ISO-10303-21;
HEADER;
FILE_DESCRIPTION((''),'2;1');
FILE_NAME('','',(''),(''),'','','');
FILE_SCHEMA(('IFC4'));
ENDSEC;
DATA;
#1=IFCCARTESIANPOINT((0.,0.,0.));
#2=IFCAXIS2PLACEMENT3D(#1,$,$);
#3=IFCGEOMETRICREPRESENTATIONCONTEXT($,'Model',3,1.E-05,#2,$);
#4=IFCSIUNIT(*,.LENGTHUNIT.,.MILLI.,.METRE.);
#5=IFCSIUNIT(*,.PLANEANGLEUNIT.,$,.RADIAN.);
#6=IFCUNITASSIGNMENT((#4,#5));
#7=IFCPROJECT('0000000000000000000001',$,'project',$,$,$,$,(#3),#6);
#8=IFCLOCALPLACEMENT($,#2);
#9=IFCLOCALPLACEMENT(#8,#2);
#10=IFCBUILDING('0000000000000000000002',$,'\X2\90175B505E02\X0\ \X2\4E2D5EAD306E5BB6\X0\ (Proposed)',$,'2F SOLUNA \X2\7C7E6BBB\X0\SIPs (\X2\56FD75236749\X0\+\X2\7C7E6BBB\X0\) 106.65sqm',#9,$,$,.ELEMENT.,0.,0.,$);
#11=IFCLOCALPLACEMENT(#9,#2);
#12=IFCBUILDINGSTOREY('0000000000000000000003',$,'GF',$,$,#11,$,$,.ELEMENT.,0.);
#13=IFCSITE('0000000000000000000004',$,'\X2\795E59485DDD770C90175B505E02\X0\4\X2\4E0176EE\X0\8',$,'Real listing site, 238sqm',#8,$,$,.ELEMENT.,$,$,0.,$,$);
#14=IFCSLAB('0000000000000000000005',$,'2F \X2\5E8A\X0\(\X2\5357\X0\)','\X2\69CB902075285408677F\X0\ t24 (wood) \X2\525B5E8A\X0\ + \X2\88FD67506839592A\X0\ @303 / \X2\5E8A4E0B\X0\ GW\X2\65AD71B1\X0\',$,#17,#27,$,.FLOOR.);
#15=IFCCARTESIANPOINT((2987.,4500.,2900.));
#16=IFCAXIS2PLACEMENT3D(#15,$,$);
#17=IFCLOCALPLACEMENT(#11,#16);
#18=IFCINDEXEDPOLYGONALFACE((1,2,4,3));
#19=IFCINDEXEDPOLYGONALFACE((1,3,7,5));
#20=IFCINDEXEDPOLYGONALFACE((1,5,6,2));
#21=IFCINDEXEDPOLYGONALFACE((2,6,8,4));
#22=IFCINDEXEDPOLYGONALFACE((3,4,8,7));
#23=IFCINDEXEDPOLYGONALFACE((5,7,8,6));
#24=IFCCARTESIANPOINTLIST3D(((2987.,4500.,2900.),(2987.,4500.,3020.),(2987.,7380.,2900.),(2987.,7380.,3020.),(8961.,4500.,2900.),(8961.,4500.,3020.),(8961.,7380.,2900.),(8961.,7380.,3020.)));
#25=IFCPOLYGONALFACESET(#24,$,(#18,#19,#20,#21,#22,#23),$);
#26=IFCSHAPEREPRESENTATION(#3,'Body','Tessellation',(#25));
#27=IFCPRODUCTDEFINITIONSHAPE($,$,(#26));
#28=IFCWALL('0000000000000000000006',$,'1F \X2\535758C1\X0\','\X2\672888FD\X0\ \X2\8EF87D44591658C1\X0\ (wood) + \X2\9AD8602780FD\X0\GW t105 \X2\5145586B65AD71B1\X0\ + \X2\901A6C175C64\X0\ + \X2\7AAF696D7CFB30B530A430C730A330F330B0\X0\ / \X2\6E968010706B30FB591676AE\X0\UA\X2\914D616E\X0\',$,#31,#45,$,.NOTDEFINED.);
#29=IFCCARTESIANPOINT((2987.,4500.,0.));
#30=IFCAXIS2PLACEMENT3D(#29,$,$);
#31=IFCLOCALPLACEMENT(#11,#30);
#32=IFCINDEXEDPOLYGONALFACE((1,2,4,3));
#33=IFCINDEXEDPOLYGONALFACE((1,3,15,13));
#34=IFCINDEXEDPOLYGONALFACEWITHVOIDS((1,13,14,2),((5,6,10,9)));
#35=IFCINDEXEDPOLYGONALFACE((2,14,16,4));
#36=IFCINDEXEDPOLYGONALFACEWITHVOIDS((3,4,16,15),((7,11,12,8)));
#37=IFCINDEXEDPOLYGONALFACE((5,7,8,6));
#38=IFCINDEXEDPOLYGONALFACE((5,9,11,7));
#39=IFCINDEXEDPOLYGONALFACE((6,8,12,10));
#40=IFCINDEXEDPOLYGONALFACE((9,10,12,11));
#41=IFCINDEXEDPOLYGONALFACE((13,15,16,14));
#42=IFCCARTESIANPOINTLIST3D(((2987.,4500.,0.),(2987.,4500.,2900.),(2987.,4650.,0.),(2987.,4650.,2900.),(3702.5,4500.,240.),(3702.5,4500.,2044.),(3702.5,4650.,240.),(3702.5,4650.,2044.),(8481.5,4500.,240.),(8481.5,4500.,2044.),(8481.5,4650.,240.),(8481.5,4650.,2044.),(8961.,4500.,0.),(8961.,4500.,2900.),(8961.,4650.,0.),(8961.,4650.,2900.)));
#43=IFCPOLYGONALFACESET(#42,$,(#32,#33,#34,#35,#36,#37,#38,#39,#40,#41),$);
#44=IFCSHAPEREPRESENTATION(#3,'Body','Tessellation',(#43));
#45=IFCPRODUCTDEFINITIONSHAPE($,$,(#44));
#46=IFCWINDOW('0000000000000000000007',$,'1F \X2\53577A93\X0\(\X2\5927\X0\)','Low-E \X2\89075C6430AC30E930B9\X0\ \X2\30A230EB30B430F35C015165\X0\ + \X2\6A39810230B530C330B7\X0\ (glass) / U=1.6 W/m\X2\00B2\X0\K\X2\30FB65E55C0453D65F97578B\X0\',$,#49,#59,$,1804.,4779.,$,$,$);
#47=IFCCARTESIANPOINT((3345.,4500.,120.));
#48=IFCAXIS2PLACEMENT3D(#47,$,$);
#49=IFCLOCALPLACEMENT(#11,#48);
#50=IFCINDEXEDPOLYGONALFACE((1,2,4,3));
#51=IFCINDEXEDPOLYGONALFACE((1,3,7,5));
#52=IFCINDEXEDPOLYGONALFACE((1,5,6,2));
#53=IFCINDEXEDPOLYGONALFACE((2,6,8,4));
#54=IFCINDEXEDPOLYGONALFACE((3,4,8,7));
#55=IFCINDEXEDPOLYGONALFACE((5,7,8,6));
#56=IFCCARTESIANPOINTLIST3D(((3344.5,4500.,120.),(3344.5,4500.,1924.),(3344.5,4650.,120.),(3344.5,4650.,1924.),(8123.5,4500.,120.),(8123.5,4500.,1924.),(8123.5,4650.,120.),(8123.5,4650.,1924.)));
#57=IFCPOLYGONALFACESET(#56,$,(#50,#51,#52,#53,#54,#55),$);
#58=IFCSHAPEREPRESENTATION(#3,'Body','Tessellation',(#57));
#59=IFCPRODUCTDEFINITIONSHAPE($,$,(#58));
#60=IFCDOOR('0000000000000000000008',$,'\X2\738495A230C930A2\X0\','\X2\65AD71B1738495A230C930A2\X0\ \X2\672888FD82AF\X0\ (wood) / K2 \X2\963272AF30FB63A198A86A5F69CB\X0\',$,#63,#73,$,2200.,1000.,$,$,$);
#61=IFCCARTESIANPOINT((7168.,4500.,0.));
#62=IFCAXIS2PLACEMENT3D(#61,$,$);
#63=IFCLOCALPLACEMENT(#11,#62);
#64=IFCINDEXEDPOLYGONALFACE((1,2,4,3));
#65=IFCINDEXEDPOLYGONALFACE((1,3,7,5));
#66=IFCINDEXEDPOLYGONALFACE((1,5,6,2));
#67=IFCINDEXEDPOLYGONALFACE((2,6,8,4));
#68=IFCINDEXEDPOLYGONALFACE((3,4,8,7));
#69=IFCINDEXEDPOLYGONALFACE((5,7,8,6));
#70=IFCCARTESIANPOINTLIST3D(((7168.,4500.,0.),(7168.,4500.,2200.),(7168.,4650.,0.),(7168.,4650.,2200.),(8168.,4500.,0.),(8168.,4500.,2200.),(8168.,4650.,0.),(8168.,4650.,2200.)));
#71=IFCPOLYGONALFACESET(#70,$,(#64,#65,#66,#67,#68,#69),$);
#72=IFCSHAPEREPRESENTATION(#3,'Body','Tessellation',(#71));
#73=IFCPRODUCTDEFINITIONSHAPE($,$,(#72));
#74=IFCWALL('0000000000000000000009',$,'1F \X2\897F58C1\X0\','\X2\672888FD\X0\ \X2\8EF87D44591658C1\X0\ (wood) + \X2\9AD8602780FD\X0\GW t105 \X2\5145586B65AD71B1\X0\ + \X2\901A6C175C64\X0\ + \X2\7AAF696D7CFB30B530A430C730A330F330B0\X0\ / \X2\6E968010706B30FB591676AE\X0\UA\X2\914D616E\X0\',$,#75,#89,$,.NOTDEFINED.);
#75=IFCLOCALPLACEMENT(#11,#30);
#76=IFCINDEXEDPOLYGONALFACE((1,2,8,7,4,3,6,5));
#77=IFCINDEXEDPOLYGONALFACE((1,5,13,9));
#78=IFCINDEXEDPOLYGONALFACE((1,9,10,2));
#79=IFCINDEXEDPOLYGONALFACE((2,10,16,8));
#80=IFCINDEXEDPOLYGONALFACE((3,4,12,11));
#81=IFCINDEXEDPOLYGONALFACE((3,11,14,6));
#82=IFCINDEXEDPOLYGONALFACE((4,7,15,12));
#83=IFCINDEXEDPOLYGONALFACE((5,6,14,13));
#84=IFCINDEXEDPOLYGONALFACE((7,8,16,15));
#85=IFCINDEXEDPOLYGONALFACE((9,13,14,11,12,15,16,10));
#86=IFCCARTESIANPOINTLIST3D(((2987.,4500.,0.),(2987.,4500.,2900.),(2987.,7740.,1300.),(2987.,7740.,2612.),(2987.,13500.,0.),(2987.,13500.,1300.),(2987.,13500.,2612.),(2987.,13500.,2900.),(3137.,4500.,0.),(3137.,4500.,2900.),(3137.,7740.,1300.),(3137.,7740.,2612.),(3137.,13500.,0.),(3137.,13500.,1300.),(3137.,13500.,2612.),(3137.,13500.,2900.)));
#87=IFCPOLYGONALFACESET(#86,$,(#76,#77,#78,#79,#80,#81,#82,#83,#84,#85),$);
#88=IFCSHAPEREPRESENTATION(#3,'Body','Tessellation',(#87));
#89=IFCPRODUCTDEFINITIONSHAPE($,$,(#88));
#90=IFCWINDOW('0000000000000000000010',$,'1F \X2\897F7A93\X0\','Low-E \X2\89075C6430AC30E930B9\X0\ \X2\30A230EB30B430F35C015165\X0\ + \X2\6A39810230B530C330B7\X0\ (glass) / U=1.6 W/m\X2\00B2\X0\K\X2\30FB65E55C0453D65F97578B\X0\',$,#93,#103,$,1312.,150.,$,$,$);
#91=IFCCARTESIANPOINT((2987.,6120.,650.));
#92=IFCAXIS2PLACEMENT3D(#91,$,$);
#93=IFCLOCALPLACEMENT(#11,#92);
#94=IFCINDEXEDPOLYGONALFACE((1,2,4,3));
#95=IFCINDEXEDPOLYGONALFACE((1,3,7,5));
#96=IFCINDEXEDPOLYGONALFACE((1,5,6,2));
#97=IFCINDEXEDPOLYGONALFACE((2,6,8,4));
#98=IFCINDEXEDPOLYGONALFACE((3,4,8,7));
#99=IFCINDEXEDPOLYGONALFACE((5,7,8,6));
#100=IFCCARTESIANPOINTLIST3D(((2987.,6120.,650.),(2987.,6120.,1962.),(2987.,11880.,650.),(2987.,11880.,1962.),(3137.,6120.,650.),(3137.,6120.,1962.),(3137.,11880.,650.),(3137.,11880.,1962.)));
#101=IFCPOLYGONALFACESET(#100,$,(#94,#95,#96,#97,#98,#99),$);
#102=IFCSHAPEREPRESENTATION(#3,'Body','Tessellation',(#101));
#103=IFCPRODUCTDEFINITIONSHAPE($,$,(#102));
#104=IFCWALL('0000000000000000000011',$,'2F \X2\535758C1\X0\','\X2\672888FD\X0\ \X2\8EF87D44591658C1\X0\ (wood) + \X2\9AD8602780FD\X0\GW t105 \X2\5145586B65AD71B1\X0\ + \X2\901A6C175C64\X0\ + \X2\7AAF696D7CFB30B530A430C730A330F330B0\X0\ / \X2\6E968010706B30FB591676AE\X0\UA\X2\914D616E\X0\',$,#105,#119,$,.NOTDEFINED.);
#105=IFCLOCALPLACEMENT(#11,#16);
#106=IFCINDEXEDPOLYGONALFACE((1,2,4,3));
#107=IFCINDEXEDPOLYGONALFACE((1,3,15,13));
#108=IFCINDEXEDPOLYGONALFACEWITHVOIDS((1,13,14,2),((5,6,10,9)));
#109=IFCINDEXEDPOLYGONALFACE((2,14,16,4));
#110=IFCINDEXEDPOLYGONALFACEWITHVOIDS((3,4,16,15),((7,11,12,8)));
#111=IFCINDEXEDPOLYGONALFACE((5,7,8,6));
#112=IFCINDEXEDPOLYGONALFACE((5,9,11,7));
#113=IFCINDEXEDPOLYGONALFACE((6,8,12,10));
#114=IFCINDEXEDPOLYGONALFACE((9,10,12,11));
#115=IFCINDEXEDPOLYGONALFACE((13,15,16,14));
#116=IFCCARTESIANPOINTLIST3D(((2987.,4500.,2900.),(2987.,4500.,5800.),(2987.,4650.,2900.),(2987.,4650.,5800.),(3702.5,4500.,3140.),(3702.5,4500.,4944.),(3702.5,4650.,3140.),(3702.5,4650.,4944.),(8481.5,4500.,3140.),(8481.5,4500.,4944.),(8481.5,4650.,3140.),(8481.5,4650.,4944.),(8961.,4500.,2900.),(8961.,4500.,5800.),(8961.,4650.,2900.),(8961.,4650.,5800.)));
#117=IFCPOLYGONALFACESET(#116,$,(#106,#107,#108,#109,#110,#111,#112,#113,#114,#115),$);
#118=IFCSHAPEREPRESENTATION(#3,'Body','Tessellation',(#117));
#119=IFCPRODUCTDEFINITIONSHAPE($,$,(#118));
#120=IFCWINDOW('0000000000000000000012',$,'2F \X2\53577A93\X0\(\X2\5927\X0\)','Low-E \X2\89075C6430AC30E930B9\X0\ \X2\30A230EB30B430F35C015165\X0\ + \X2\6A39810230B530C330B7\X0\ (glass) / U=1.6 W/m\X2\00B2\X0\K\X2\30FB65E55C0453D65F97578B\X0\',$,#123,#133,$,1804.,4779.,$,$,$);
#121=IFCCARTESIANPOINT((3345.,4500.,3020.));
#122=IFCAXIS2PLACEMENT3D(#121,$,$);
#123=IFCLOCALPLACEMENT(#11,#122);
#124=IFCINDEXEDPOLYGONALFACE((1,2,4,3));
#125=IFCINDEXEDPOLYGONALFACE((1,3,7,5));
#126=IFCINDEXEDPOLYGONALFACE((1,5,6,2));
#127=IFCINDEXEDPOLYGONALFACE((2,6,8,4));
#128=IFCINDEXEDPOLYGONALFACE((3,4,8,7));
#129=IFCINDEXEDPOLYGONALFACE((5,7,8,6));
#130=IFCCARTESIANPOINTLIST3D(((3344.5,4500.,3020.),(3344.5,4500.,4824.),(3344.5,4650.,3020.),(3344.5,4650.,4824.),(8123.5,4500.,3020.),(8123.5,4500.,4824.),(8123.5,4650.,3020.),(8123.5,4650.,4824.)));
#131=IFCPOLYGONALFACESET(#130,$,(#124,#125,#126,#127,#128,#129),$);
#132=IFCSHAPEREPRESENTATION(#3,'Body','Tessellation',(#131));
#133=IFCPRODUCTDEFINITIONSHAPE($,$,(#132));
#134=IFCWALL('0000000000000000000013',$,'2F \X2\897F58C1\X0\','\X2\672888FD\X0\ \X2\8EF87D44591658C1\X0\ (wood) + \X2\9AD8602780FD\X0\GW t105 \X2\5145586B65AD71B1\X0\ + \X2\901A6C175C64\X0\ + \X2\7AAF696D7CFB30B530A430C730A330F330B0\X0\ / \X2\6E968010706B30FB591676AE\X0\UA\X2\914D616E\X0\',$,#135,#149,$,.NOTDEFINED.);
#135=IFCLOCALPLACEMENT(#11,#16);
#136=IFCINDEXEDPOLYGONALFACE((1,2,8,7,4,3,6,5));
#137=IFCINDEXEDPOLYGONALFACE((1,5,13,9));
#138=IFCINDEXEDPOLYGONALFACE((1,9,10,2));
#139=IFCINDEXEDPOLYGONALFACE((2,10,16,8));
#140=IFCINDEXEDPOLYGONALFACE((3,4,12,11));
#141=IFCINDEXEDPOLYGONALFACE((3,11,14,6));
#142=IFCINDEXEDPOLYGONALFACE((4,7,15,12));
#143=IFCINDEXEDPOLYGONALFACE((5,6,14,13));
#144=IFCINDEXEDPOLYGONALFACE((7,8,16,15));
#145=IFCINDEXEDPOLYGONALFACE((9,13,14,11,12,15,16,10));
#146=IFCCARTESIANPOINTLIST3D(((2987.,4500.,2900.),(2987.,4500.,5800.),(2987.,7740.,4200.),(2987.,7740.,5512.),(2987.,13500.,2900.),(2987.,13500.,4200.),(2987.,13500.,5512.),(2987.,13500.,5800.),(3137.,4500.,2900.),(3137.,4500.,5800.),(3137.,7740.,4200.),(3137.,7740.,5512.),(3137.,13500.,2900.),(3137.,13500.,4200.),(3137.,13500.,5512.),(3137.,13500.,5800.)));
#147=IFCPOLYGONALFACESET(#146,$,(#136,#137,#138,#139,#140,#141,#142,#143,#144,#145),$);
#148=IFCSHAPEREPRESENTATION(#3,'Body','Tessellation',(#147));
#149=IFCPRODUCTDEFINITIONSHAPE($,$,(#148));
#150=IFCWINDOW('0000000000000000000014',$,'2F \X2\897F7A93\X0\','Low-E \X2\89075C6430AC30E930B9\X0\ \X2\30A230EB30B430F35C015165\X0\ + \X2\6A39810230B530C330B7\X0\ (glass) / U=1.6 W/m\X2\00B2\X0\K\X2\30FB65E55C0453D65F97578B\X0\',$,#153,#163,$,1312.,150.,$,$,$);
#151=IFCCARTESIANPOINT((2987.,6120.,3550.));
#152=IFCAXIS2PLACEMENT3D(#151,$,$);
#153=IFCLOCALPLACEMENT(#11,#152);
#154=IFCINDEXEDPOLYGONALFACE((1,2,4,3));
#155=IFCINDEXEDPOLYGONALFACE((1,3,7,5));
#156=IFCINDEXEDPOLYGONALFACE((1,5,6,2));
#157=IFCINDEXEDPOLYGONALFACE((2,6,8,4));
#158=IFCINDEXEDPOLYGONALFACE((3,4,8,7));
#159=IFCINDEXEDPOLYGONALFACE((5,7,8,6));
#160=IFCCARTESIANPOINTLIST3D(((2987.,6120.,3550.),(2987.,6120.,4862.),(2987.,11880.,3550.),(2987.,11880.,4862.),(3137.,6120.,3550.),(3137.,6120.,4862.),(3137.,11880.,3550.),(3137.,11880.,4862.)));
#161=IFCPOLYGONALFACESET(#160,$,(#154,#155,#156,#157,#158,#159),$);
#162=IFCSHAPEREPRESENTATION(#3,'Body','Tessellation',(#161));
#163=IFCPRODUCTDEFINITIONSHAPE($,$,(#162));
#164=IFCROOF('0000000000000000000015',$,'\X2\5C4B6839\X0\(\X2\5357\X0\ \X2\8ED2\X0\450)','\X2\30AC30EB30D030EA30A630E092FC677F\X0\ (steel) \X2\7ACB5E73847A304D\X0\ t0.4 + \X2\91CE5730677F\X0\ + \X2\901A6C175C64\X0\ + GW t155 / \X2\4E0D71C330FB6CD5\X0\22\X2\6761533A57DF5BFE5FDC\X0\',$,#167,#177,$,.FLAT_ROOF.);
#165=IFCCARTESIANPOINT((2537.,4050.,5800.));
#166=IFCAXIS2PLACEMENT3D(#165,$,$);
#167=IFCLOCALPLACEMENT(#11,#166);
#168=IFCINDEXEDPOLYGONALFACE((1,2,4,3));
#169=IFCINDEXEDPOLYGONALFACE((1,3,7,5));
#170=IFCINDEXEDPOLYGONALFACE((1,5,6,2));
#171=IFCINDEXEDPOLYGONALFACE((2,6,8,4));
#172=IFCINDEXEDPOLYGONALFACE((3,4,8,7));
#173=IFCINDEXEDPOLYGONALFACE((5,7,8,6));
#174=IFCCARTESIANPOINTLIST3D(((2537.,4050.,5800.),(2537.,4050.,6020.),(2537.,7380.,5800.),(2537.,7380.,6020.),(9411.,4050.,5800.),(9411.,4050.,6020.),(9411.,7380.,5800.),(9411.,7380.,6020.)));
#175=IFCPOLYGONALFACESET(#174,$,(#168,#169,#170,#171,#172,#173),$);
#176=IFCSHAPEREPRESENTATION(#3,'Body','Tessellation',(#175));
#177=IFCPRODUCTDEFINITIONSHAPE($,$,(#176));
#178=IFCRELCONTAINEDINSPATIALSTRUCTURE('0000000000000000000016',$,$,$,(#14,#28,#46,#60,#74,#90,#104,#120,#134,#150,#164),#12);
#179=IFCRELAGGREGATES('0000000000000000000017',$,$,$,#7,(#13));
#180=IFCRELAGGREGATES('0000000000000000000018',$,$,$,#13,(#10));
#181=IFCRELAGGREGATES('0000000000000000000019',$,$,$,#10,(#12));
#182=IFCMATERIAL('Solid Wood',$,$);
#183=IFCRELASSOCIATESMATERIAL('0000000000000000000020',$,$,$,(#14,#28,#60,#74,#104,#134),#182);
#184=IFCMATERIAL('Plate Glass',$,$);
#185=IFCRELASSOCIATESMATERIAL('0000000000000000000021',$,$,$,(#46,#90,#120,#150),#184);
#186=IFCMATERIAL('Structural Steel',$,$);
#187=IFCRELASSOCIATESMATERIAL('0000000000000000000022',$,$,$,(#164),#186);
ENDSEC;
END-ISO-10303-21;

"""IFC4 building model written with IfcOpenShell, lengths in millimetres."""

from ifc_helpers import new_model, si_unit, frame, frame_2d, origin, place, context, project, spatial, rectangle, extrude, material, element, fill, save


model = new_model("IFC4")

# Units and contexts
model_context = context("Model", 3, precision=1e-05, world=origin())
ifc_project = project(units=[si_unit("LENGTHUNIT", "METRE", prefix="MILLI"), si_unit("PLANEANGLEUNIT", "RADIAN")], contexts=[model_context])

# Site, building, storey
site_placement = place(None, origin())
site = spatial("IfcSite", under=ifc_project, at=site_placement, Name="神奈川県逗子市4丁目8", ObjectType="Real listing site, 238sqm", CompositionType="ELEMENT", RefElevation=0.0)
building_placement = place(site_placement, origin())
building = spatial("IfcBuilding", under=site, at=building_placement, Name="逗子市 中庭の家 (Proposed)", ObjectType="2F SOLUNA 籾殻SIPs (国産杉+籾殻) 106.65sqm", CompositionType="ELEMENT", ElevationOfRefHeight=0.0, ElevationOfTerrain=0.0)
storey_placement = place(building_placement, origin())
storey = spatial("IfcBuildingStorey", under=building, at=storey_placement, Name="GF", CompositionType="ELEMENT", Elevation=0.0)

# Slab
ifc_material_1 = material(Name="Solid Wood")
slab_1_placement = place(storey_placement, frame((2987.0, 4500.0, 2900.0)))
element("IfcSlab", 1, at=slab_1_placement, inside=storey, material=ifc_material_1, Name="2F 床(南)", Description="構造用合板 t24 (wood) 剛床 + 製材根太 @303 / 床下 GW断熱", PredefinedType="FLOOR", context=model_context, shape_type="SweptSolid", body=[
    extrude(rectangle(XDim=5974.0, YDim=2880.0, at=frame_2d((2987.0, 1440.0))), frame((2987.0, 4500.0, 2900.0)), (0.0, 0.0, 1.0), 120.0),
])

# Wall, openings, window, door
wall_1_placement = place(storey_placement, frame((2987.0, 4500.0, 0.0)))
wall_1 = element("IfcWall", 2, at=wall_1_placement, inside=storey, material=ifc_material_1, Name="1F 南壁", Description="木製 軸組外壁 (wood) + 高性能GW t105 充填断熱 + 通気層 + 窯業系サイディング / 準耐火・外皮UA配慮", PredefinedType="NOTDEFINED", context=model_context, shape_type="SweptSolid", body=[
    extrude(rectangle(XDim=5974.0, YDim=150.0, at=frame_2d((2987.0, 75.0))), frame((2987.0, 4500.0, 0.0)), (0.0, 0.0, 1.0), 2900.0),
])
opening_1_placement = place(storey_placement, frame((3345.0, 4500.0, 120.0)))
opening_1 = element("IfcOpeningElement", 3, at=opening_1_placement, cuts=wall_1, PredefinedType="NOTDEFINED", context=model_context, shape_type="SweptSolid", body=[
    extrude(rectangle(XDim=4779.0, YDim=150.0, at=frame_2d((2389.0, 75.0))), frame((3345.0, 4500.0, 120.0)), (0.0, 0.0, 1.0), 1804.0),
])
opening_2_placement = place(storey_placement, frame((7168.0, 4500.0, 0.0)))
opening_2 = element("IfcOpeningElement", 4, at=opening_2_placement, cuts=wall_1, PredefinedType="NOTDEFINED", context=model_context, shape_type="SweptSolid", body=[
    extrude(rectangle(XDim=1000.0, YDim=150.0, at=frame_2d((500.0, 75.0))), frame((7168.0, 4500.0, 0.0)), (0.0, 0.0, 1.0), 2200.0),
])
ifc_material_2 = material(Name="Plate Glass")
window_1_placement = place(storey_placement, frame((3345.0, 4500.0, 120.0)))
window_1 = element("IfcWindow", 5, at=window_1_placement, inside=storey, material=ifc_material_2, Name="1F 南窓(大)", Description="Low-E 複層ガラス アルゴン封入 + 樹脂サッシ (glass) / U=1.6 W/m²K・日射取得型", OverallHeight=1804.0, OverallWidth=4779.0, context=model_context, shape_type="SweptSolid", body=[
    extrude(rectangle(XDim=4779.0, YDim=150.0, at=frame_2d((2389.0, 75.0))), frame((3345.0, 4500.0, 120.0)), (0.0, 0.0, 1.0), 1804.0),
])
fill(opening_1, window_1)
door_placement = place(storey_placement, frame((7168.0, 4500.0, 0.0)))
door = element("IfcDoor", 6, at=door_placement, inside=storey, material=ifc_material_1, Name="玄関ドア", Description="断熱玄関ドア 木製芯 (wood) / K2 防犯・採風機構", OverallHeight=2200.0, OverallWidth=1000.0, context=model_context, shape_type="SweptSolid", body=[
    extrude(rectangle(XDim=1000.0, YDim=150.0, at=frame_2d((500.0, 75.0))), frame((7168.0, 4500.0, 0.0)), (0.0, 0.0, 1.0), 2200.0),
])
fill(opening_2, door)

# Walls, openings, windows
wall_2_placement = place(storey_placement, frame((2987.0, 4500.0, 0.0)))
wall_2 = element("IfcWall", 7, at=wall_2_placement, inside=storey, material=ifc_material_1, Name="1F 西壁", Description="木製 軸組外壁 (wood) + 高性能GW t105 充填断熱 + 通気層 + 窯業系サイディング / 準耐火・外皮UA配慮", PredefinedType="NOTDEFINED", context=model_context, shape_type="SweptSolid", body=[
    extrude(rectangle(XDim=150.0, YDim=9000.0, at=frame_2d((75.0, 4500.0))), frame((2987.0, 4500.0, 0.0)), (0.0, 0.0, 1.0), 2900.0),
])
opening_3_placement = place(storey_placement, frame((2987.0, 6120.0, 650.0)))
opening_3 = element("IfcOpeningElement", 8, at=opening_3_placement, cuts=wall_2, PredefinedType="NOTDEFINED", context=model_context, shape_type="SweptSolid", body=[
    extrude(rectangle(XDim=150.0, YDim=5760.0, at=frame_2d((75.0, 2880.0))), frame((2987.0, 6120.0, 650.0)), (0.0, 0.0, 1.0), 1312.0),
])
window_2_placement = place(storey_placement, frame((2987.0, 6120.0, 650.0)))
window_2 = element("IfcWindow", 9, at=window_2_placement, inside=storey, material=ifc_material_2, Name="1F 西窓", Description="Low-E 複層ガラス アルゴン封入 + 樹脂サッシ (glass) / U=1.6 W/m²K・日射取得型", OverallHeight=1312.0, OverallWidth=150.0, context=model_context, shape_type="SweptSolid", body=[
    extrude(rectangle(XDim=150.0, YDim=5760.0, at=frame_2d((75.0, 2880.0))), frame((2987.0, 6120.0, 650.0)), (0.0, 0.0, 1.0), 1312.0),
])
fill(opening_3, window_2)
wall_3_placement = place(storey_placement, frame((2987.0, 4500.0, 2900.0)))
wall_3 = element("IfcWall", 10, at=wall_3_placement, inside=storey, material=ifc_material_1, Name="2F 南壁", Description="木製 軸組外壁 (wood) + 高性能GW t105 充填断熱 + 通気層 + 窯業系サイディング / 準耐火・外皮UA配慮", PredefinedType="NOTDEFINED", context=model_context, shape_type="SweptSolid", body=[
    extrude(rectangle(XDim=5974.0, YDim=150.0, at=frame_2d((2987.0, 75.0))), frame((2987.0, 4500.0, 2900.0)), (0.0, 0.0, 1.0), 2900.0),
])
opening_4_placement = place(storey_placement, frame((3345.0, 4500.0, 3020.0)))
opening_4 = element("IfcOpeningElement", 11, at=opening_4_placement, cuts=wall_3, PredefinedType="NOTDEFINED", context=model_context, shape_type="SweptSolid", body=[
    extrude(rectangle(XDim=4779.0, YDim=150.0, at=frame_2d((2389.0, 75.0))), frame((3345.0, 4500.0, 3020.0)), (0.0, 0.0, 1.0), 1804.0),
])
window_3_placement = place(storey_placement, frame((3345.0, 4500.0, 3020.0)))
window_3 = element("IfcWindow", 12, at=window_3_placement, inside=storey, material=ifc_material_2, Name="2F 南窓(大)", Description="Low-E 複層ガラス アルゴン封入 + 樹脂サッシ (glass) / U=1.6 W/m²K・日射取得型", OverallHeight=1804.0, OverallWidth=4779.0, context=model_context, shape_type="SweptSolid", body=[
    extrude(rectangle(XDim=4779.0, YDim=150.0, at=frame_2d((2389.0, 75.0))), frame((3345.0, 4500.0, 3020.0)), (0.0, 0.0, 1.0), 1804.0),
])
fill(opening_4, window_3)
wall_4_placement = place(storey_placement, frame((2987.0, 4500.0, 2900.0)))
wall_4 = element("IfcWall", 13, at=wall_4_placement, inside=storey, material=ifc_material_1, Name="2F 西壁", Description="木製 軸組外壁 (wood) + 高性能GW t105 充填断熱 + 通気層 + 窯業系サイディング / 準耐火・外皮UA配慮", PredefinedType="NOTDEFINED", context=model_context, shape_type="SweptSolid", body=[
    extrude(rectangle(XDim=150.0, YDim=9000.0, at=frame_2d((75.0, 4500.0))), frame((2987.0, 4500.0, 2900.0)), (0.0, 0.0, 1.0), 2900.0),
])
opening_5_placement = place(storey_placement, frame((2987.0, 6120.0, 3550.0)))
opening_5 = element("IfcOpeningElement", 14, at=opening_5_placement, cuts=wall_4, PredefinedType="NOTDEFINED", context=model_context, shape_type="SweptSolid", body=[
    extrude(rectangle(XDim=150.0, YDim=5760.0, at=frame_2d((75.0, 2880.0))), frame((2987.0, 6120.0, 3550.0)), (0.0, 0.0, 1.0), 1312.0),
])
window_4_placement = place(storey_placement, frame((2987.0, 6120.0, 3550.0)))
window_4 = element("IfcWindow", 15, at=window_4_placement, inside=storey, material=ifc_material_2, Name="2F 西窓", Description="Low-E 複層ガラス アルゴン封入 + 樹脂サッシ (glass) / U=1.6 W/m²K・日射取得型", OverallHeight=1312.0, OverallWidth=150.0, context=model_context, shape_type="SweptSolid", body=[
    extrude(rectangle(XDim=150.0, YDim=5760.0, at=frame_2d((75.0, 2880.0))), frame((2987.0, 6120.0, 3550.0)), (0.0, 0.0, 1.0), 1312.0),
])
fill(opening_5, window_4)

# Roof
ifc_material_3 = material(Name="Structural Steel")
roof_1_placement = place(storey_placement, frame((2537.0, 4050.0, 5800.0)))
element("IfcRoof", 16, at=roof_1_placement, inside=storey, material=ifc_material_3, Name="屋根(南 軒450)", Description="ガルバリウム鋼板 (steel) 立平葺き t0.4 + 野地板 + 通気層 + GW t155 / 不燃・法22条区域対応", PredefinedType="FLAT_ROOF", context=model_context, shape_type="SweptSolid", body=[
    extrude(rectangle(XDim=6874.0, YDim=3330.0, at=frame_2d((3437.0, 1665.0))), frame((2537.0, 4050.0, 5800.0)), (0.0, 0.0, 1.0), 220.0),
])

save(model, "model.ifc")
